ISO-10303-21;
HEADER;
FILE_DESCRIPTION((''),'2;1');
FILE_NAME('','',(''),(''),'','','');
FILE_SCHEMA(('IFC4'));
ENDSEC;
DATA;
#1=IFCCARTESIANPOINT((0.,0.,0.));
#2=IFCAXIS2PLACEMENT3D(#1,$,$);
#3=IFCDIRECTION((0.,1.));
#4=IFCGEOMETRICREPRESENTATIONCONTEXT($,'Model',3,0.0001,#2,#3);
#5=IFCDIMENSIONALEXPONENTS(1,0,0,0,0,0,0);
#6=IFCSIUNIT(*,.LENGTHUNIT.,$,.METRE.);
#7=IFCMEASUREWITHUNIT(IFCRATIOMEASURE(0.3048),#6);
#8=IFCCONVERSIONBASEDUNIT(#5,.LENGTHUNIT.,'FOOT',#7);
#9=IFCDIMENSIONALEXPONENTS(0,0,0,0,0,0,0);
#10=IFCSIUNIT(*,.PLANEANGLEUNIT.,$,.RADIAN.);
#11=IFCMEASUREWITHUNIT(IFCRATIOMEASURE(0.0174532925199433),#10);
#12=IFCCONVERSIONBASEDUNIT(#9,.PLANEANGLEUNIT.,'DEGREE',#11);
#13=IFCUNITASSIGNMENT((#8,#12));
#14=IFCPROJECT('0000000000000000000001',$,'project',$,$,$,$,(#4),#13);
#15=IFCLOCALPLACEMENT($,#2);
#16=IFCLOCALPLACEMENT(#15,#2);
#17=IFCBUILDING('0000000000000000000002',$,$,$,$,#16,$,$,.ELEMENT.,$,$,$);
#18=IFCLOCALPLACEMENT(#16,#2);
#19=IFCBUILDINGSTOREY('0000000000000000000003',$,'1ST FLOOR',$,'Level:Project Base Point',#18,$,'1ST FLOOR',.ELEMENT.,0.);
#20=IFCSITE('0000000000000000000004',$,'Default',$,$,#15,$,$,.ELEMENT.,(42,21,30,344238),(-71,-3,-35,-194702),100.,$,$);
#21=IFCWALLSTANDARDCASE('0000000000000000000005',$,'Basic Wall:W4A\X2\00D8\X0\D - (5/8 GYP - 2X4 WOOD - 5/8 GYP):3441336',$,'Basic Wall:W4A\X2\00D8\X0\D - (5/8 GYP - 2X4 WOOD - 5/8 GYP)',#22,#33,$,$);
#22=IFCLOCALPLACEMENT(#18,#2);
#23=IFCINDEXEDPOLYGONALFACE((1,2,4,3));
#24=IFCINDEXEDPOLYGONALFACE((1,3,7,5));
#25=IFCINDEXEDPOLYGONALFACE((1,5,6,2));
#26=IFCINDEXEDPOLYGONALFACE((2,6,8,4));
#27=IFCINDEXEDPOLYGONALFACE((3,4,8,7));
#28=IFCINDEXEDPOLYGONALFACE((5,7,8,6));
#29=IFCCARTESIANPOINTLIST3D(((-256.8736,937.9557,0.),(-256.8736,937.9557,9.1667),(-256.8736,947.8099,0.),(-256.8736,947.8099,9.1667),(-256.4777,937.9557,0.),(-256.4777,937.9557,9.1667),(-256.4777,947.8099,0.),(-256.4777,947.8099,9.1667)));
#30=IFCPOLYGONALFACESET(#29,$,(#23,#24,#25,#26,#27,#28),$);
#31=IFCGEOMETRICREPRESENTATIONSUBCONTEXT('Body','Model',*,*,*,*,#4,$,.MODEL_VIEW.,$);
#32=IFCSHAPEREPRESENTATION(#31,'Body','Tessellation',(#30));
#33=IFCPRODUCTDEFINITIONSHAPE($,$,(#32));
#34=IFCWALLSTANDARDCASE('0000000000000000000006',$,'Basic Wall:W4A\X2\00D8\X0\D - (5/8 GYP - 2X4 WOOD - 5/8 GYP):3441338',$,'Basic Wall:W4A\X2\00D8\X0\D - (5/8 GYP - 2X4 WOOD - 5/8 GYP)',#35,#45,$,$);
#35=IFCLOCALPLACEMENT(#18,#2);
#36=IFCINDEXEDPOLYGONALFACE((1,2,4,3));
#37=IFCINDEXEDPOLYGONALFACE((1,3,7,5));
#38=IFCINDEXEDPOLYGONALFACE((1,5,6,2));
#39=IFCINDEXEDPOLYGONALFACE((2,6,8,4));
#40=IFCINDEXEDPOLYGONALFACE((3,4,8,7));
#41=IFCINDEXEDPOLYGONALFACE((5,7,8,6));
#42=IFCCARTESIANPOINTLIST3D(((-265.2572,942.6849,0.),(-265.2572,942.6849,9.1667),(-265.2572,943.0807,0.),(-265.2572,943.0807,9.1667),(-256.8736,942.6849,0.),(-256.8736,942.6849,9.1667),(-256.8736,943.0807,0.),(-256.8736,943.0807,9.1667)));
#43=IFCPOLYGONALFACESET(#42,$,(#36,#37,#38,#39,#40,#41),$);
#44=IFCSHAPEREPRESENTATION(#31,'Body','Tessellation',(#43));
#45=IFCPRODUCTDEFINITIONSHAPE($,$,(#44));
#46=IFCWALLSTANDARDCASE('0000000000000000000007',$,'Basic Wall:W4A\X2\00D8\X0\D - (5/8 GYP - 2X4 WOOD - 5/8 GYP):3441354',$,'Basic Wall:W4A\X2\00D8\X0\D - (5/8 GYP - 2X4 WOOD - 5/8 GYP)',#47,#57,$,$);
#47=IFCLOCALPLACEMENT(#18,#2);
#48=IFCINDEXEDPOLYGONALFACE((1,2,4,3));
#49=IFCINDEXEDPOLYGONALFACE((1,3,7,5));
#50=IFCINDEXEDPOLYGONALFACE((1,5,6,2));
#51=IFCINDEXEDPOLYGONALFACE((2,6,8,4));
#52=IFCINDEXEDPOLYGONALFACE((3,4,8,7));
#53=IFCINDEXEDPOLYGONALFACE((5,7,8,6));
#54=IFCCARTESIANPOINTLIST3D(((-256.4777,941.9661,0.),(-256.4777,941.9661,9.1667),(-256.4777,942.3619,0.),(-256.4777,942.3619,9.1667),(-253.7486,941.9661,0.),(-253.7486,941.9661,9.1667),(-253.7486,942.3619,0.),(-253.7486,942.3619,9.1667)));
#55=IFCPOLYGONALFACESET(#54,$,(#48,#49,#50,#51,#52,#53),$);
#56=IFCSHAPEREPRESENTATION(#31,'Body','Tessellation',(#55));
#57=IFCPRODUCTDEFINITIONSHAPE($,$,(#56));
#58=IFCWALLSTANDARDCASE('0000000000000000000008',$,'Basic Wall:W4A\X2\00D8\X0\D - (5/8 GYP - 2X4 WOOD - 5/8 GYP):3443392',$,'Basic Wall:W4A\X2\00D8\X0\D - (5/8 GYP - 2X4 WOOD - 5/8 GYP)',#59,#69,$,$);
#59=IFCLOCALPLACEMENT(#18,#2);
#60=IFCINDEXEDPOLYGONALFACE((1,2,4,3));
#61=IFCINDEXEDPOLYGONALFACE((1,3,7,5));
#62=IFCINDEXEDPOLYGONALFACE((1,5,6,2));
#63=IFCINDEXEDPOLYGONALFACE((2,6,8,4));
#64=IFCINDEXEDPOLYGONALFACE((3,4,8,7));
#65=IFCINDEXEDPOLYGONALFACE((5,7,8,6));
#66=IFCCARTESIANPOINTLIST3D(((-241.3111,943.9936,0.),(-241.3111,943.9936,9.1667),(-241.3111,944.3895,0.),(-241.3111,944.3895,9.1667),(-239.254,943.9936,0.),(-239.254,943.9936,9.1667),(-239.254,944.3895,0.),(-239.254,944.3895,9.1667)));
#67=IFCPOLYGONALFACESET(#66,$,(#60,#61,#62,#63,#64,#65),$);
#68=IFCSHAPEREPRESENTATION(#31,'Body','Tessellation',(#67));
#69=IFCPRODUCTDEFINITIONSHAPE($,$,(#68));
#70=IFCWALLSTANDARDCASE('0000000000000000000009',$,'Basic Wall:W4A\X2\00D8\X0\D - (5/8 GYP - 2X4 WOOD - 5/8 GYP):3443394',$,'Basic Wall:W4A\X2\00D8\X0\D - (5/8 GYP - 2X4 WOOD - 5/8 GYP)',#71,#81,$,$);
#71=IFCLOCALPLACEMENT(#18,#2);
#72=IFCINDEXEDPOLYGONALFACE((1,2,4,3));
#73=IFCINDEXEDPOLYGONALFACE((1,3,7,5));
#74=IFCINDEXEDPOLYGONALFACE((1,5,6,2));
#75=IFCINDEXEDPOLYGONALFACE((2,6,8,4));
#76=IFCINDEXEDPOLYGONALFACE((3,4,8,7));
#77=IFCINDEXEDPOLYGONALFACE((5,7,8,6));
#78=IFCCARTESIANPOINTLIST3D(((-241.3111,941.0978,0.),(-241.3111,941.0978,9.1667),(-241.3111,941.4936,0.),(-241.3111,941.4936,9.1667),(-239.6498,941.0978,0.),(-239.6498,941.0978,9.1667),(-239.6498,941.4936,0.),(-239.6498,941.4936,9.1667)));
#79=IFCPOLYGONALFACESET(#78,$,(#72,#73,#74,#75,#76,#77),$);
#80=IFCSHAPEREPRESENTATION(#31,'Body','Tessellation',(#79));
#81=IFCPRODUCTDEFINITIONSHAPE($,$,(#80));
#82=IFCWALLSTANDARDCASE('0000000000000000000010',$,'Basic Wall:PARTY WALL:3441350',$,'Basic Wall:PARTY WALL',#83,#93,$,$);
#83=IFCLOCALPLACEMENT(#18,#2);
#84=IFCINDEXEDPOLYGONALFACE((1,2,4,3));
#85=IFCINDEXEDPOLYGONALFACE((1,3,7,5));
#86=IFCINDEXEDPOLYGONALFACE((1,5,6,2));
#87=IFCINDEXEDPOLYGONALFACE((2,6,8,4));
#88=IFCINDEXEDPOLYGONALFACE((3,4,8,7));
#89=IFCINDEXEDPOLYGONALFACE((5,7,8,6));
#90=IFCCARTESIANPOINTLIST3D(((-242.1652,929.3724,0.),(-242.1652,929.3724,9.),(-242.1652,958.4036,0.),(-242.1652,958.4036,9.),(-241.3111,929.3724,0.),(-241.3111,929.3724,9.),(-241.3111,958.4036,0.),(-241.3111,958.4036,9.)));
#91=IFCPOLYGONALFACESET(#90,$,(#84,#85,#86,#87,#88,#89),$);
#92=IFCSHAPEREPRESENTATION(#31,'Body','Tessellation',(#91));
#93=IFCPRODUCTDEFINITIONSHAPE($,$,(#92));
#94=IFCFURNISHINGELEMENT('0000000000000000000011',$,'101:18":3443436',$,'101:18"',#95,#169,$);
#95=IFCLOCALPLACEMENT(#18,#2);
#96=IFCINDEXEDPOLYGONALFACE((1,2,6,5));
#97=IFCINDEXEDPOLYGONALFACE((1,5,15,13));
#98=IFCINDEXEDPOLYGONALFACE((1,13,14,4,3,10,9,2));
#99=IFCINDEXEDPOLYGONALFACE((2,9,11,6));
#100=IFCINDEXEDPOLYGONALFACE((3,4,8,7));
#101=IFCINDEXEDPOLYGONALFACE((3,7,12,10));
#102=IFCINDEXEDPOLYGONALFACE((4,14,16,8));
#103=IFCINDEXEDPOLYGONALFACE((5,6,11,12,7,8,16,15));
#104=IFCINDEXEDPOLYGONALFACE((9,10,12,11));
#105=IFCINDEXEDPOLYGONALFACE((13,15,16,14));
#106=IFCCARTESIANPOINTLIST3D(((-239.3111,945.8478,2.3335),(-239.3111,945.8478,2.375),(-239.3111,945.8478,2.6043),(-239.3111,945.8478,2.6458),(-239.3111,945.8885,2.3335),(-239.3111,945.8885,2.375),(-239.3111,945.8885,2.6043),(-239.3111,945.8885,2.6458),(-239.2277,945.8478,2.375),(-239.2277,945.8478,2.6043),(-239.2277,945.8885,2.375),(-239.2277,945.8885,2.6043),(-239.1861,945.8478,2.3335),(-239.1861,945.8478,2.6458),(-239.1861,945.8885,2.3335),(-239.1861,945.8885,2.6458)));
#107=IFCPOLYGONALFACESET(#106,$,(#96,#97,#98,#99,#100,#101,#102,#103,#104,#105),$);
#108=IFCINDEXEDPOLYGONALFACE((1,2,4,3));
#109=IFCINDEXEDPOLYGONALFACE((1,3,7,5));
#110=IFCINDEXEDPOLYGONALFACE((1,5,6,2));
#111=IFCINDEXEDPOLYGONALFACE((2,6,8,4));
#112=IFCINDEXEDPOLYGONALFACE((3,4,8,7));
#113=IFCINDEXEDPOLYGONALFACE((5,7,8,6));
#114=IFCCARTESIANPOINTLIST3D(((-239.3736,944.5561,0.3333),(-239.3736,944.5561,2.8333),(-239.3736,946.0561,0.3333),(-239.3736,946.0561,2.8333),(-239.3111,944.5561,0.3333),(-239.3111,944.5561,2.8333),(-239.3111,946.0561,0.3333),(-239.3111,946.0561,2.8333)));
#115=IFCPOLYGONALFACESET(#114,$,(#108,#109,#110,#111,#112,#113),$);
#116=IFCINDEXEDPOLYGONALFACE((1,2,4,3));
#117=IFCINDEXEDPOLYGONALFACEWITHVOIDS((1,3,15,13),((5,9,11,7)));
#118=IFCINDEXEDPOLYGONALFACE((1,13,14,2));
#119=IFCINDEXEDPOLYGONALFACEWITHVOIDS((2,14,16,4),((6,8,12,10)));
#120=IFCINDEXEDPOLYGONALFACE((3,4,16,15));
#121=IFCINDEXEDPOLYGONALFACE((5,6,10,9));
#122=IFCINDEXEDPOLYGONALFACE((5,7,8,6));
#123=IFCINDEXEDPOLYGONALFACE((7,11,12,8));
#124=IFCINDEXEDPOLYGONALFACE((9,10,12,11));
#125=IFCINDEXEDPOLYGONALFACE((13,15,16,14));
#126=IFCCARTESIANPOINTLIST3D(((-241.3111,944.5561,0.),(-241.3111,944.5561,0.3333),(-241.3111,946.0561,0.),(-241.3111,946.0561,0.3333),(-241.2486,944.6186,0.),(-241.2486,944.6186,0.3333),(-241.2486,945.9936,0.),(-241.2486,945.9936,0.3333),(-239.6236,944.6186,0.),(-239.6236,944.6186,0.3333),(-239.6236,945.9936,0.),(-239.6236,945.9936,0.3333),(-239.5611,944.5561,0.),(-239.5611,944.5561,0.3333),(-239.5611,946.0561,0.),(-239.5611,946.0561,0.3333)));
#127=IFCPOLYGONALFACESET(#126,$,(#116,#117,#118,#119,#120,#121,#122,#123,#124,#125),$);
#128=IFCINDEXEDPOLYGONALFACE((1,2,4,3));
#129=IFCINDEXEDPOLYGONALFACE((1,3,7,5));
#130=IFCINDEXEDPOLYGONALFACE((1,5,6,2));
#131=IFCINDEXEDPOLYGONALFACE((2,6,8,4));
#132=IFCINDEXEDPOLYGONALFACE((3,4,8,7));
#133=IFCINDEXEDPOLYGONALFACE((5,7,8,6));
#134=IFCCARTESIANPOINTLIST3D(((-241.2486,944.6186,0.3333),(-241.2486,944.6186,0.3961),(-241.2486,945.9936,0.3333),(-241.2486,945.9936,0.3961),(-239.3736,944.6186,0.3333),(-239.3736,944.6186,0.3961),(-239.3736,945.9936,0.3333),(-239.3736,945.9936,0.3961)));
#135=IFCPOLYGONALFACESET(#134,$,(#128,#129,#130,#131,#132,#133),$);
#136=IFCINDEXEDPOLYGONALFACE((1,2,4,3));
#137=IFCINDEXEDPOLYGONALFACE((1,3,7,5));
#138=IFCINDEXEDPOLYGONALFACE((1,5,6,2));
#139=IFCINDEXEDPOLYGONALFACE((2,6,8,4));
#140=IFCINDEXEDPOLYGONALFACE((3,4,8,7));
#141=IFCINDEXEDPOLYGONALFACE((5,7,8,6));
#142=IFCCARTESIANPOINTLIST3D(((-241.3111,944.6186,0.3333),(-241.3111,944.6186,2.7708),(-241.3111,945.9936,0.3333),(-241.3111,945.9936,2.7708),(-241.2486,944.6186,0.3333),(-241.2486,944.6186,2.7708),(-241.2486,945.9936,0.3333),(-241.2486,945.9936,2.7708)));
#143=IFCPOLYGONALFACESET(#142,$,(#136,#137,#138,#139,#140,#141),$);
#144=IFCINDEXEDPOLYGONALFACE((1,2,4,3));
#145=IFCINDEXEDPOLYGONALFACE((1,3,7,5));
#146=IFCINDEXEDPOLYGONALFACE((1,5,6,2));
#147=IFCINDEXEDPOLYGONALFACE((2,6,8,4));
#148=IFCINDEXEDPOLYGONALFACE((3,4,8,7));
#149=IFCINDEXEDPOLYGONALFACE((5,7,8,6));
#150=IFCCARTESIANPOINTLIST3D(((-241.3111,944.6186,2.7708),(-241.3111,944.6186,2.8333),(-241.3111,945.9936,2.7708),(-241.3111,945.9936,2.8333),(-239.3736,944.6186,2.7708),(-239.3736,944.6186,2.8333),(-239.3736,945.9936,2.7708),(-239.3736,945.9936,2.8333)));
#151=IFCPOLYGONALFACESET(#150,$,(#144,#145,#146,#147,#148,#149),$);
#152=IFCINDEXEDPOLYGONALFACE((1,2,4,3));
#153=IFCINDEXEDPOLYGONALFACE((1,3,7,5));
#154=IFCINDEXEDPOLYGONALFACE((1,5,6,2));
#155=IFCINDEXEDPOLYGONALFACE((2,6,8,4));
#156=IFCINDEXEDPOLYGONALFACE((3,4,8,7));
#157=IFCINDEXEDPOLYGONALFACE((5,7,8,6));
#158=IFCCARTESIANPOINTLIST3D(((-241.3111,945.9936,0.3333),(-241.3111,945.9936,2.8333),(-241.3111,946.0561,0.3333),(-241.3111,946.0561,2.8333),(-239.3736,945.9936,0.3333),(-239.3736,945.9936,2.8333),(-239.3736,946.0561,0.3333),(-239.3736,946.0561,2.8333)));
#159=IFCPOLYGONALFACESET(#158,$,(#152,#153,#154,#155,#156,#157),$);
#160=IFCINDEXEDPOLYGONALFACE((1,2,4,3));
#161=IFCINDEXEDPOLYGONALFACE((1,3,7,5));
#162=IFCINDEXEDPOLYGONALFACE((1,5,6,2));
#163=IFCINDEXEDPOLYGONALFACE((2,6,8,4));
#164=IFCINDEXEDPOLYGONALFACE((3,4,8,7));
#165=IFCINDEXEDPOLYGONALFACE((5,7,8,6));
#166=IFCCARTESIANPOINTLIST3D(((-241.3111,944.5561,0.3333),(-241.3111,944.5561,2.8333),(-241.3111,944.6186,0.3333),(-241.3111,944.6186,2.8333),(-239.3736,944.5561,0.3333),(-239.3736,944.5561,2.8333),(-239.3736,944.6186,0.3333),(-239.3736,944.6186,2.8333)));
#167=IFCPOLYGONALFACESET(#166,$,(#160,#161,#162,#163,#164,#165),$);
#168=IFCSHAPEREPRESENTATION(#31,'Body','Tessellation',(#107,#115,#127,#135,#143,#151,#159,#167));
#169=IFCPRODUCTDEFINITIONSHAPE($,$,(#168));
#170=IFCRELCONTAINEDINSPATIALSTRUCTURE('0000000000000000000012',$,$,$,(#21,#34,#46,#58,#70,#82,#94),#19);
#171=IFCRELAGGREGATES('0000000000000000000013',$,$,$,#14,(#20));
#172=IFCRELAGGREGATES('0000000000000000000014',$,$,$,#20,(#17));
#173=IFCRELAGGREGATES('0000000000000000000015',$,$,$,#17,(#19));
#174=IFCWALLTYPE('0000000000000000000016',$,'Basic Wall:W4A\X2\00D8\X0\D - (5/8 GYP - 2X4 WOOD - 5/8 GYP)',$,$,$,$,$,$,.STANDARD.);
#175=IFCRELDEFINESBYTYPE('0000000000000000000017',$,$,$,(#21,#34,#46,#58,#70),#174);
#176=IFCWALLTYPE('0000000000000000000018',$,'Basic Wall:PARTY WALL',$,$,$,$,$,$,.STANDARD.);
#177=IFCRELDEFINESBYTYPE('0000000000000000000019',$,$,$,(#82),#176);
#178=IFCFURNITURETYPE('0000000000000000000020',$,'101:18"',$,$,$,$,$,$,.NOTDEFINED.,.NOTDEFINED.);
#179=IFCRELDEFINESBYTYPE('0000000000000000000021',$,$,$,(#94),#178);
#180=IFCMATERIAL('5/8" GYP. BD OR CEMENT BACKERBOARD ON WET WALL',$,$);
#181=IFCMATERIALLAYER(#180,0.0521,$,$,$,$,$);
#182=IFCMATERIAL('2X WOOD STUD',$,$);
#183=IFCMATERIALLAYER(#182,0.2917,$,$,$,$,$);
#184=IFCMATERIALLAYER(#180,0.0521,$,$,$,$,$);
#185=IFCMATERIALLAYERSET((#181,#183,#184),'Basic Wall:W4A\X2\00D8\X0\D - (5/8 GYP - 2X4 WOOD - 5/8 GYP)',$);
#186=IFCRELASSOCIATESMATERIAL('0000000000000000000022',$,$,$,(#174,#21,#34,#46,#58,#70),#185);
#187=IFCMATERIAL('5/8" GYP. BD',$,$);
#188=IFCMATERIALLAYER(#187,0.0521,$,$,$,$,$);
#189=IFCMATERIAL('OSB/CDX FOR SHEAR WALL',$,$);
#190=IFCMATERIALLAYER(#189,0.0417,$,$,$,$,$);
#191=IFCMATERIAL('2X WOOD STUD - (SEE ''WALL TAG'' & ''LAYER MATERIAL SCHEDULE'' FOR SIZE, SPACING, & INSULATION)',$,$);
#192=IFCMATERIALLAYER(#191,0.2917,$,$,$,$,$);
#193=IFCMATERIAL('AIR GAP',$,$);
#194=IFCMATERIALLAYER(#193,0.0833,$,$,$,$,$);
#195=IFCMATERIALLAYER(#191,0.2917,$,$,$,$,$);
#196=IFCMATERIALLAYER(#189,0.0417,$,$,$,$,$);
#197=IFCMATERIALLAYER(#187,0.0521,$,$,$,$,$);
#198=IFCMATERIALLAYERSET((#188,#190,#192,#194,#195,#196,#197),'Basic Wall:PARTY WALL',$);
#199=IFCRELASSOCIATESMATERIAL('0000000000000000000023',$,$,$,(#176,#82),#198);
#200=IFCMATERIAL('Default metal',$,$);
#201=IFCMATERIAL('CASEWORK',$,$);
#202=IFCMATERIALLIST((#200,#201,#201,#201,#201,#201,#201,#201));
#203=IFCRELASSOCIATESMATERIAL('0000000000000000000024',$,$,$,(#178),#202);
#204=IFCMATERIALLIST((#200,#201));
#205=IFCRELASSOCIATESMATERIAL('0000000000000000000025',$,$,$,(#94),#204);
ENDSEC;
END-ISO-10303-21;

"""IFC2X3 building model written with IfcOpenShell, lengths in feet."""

from ifc_helpers import new_model, entity, si_unit, converted_unit, direction, frame, frame_2d, origin, origin_2d_with_axis, place, context, subcontext, project, spatial, polyline, rectangle, outline, extrude, source, transform, mapped, material, material_list, layer, layer_set, layer_usage, type_object, type_shapes, element, save


model = new_model("IFC2X3")

# Units and contexts
model_context = context("Model", 3, precision=0.0001, world=origin(), true_north=direction((0.0, 1.0)))
body_context = subcontext(model_context, "Body", "Model", "MODEL_VIEW")
ifc_project = project(units=[converted_unit("LENGTHUNIT", "FOOT", entity("IfcRatioMeasure", 0.3048), si_unit("LENGTHUNIT", "METRE"), dimensions=[1, 0, 0, 0, 0, 0, 0]), converted_unit("PLANEANGLEUNIT", "DEGREE", entity("IfcRatioMeasure", 0.0174532925199433), si_unit("PLANEANGLEUNIT", "RADIAN"), dimensions=[0, 0, 0, 0, 0, 0, 0])], contexts=[model_context])

# Site, building, storey
site_placement = place(None, origin())
site = spatial("IfcSite", under=ifc_project, at=site_placement, Name="Default", CompositionType="ELEMENT", RefLatitude=(42, 21, 30, 344238), RefLongitude=(-71, -3, -35, -194702), RefElevation=100.0)
building_placement = place(site_placement, origin())
building = spatial("IfcBuilding", under=site, at=building_placement, CompositionType="ELEMENT")
storey_placement = place(building_placement, origin())
storey = spatial("IfcBuildingStorey", under=building, at=storey_placement, Name="1ST FLOOR", ObjectType="Level:Project Base Point", LongName="1ST FLOOR", CompositionType="ELEMENT", Elevation=0.0)

# Shared definitions
ifc_material_1 = material(Name="5/8\" GYP. BD OR CEMENT BACKERBOARD ON WET WALL")
ifc_layer_1 = layer(ifc_material_1, 0.0521)
ifc_material_2 = material(Name="2X WOOD STUD")
ifc_layer_2 = layer(ifc_material_2, 0.2917)
ifc_layer_3 = layer(ifc_material_1, 0.0521)
ifc_layer_set_1 = layer_set([ifc_layer_1, ifc_layer_2, ifc_layer_3], Name="Basic Wall:W4AØD - (5/8 GYP - 2X4 WOOD - 5/8 GYP)")
wall_type_1 = type_object("IfcWallType", Name="Basic Wall:W4AØD - (5/8 GYP - 2X4 WOOD - 5/8 GYP)", PredefinedType="STANDARD", material=ifc_layer_set_1)

# Walls
ifc_layer_usage_1 = layer_usage(ifc_layer_set_1, "AXIS2", "NEGATIVE", 0.1979)
wall_1_placement = place(storey_placement, frame((-256.6757, 937.9557, 0.0), z_axis=(0.0, 0.0, 1.0), x_axis=(0.0, 1.0, 0.0)))
element("IfcWallStandardCase", 1, at=wall_1_placement, inside=storey, type_object=wall_type_1, material=ifc_layer_usage_1, Name="Basic Wall:W4AØD - (5/8 GYP - 2X4 WOOD - 5/8 GYP):3441336", ObjectType="Basic Wall:W4AØD - (5/8 GYP - 2X4 WOOD - 5/8 GYP)", context=body_context, shape_type="SweptSolid", body=[
    extrude(rectangle(XDim=9.8542, YDim=0.3958, at=frame_2d((4.9271, 0.0), x_axis=(-1.0, 0.0))), origin(), (0.0, 0.0, 1.0), 9.1667),
])
ifc_layer_usage_2 = layer_usage(ifc_layer_set_1, "AXIS2", "POSITIVE", -0.1979)
wall_2_placement = place(storey_placement, frame((-256.8736, 942.8828, 0.0), z_axis=(0.0, 0.0, 1.0), x_axis=(-1.0, 0.0, 0.0)))
element("IfcWallStandardCase", 2, at=wall_2_placement, inside=storey, type_object=wall_type_1, material=ifc_layer_usage_2, Name="Basic Wall:W4AØD - (5/8 GYP - 2X4 WOOD - 5/8 GYP):3441338", ObjectType="Basic Wall:W4AØD - (5/8 GYP - 2X4 WOOD - 5/8 GYP)", context=body_context, shape_type="SweptSolid", body=[
    extrude(rectangle(XDim=8.3836, YDim=0.3958, at=frame_2d((4.1918, 0.0), x_axis=(-1.0, 0.0))), origin(), (0.0, 0.0, 1.0), 9.1667),
])
ifc_layer_usage_3 = layer_usage(ifc_layer_set_1, "AXIS2", "NEGATIVE", 0.1979)
wall_3_placement = place(storey_placement, frame((-256.4777, 942.164, 0.0)))
element("IfcWallStandardCase", 3, at=wall_3_placement, inside=storey, type_object=wall_type_1, material=ifc_layer_usage_3, Name="Basic Wall:W4AØD - (5/8 GYP - 2X4 WOOD - 5/8 GYP):3441354", ObjectType="Basic Wall:W4AØD - (5/8 GYP - 2X4 WOOD - 5/8 GYP)", context=body_context, shape_type="SweptSolid", body=[
    extrude(rectangle(XDim=2.7292, YDim=0.3958, at=frame_2d((1.3646, 0.0), x_axis=(-1.0, 0.0))), origin(), (0.0, 0.0, 1.0), 9.1667),
])
ifc_layer_usage_4 = layer_usage(ifc_layer_set_1, "AXIS2", "NEGATIVE", 0.1979)
wall_4_placement = place(storey_placement, frame((-241.3111, 944.1916, 0.0)))
element("IfcWallStandardCase", 4, at=wall_4_placement, inside=storey, type_object=wall_type_1, material=ifc_layer_usage_4, Name="Basic Wall:W4AØD - (5/8 GYP - 2X4 WOOD - 5/8 GYP):3443392", ObjectType="Basic Wall:W4AØD - (5/8 GYP - 2X4 WOOD - 5/8 GYP)", context=body_context, shape_type="SweptSolid", body=[
    extrude(rectangle(XDim=2.0571, YDim=0.3958, at=frame_2d((1.0285, 0.0), x_axis=(-1.0, 0.0))), origin(), (0.0, 0.0, 1.0), 9.1667),
])
ifc_layer_usage_5 = layer_usage(ifc_layer_set_1, "AXIS2", "NEGATIVE", 0.1979)
wall_5_placement = place(storey_placement, frame((-239.6498, 941.2957, 0.0), z_axis=(0.0, 0.0, 1.0), x_axis=(-1.0, 0.0, 0.0)))
element("IfcWallStandardCase", 5, at=wall_5_placement, inside=storey, type_object=wall_type_1, material=ifc_layer_usage_5, Name="Basic Wall:W4AØD - (5/8 GYP - 2X4 WOOD - 5/8 GYP):3443394", ObjectType="Basic Wall:W4AØD - (5/8 GYP - 2X4 WOOD - 5/8 GYP)", context=body_context, shape_type="SweptSolid", body=[
    extrude(rectangle(XDim=1.6612, YDim=0.3958, at=frame_2d((0.8306, 0.0), x_axis=(-1.0, 0.0))), origin(), (0.0, 0.0, 1.0), 9.1667),
])
ifc_material_3 = material(Name="5/8\" GYP. BD")
ifc_layer_4 = layer(ifc_material_3, 0.0521)
ifc_material_4 = material(Name="OSB/CDX FOR SHEAR WALL")
ifc_layer_5 = layer(ifc_material_4, 0.0417)
ifc_material_5 = material(Name="2X WOOD STUD - (SEE 'WALL TAG' & 'LAYER MATERIAL SCHEDULE' FOR SIZE, SPACING, & INSULATION)")
ifc_layer_6 = layer(ifc_material_5, 0.2917)
ifc_material_6 = material(Name="AIR GAP")
ifc_layer_7 = layer(ifc_material_6, 0.0833)
ifc_layer_8 = layer(ifc_material_5, 0.2917)
ifc_layer_9 = layer(ifc_material_4, 0.0417)
ifc_layer_10 = layer(ifc_material_3, 0.0521)
ifc_layer_set_2 = layer_set([ifc_layer_4, ifc_layer_5, ifc_layer_6, ifc_layer_7, ifc_layer_8, ifc_layer_9, ifc_layer_10], Name="Basic Wall:PARTY WALL")
ifc_layer_usage_6 = layer_usage(ifc_layer_set_2, "AXIS2", "POSITIVE", -0.4271)
wall_type_2 = type_object("IfcWallType", Name="Basic Wall:PARTY WALL", PredefinedType="STANDARD", material=ifc_layer_set_2)
wall_6_placement = place(storey_placement, frame((-241.7382, 929.3724, 0.0), z_axis=(0.0, 0.0, 1.0), x_axis=(0.0, 1.0, 0.0)))
element("IfcWallStandardCase", 6, at=wall_6_placement, inside=storey, type_object=wall_type_2, material=ifc_layer_usage_6, Name="Basic Wall:PARTY WALL:3441350", ObjectType="Basic Wall:PARTY WALL", context=body_context, shape_type="SweptSolid", body=[
    extrude(rectangle(XDim=29.0313, YDim=0.8542, at=frame_2d((14.5156, 0.0), x_axis=(-1.0, 0.0))), origin(), (0.0, 0.0, 1.0), 9.0),
])

# Furnishing element
ifc_material_7 = material(Name="Default metal")
ifc_material_8 = material(Name="CASEWORK")
ifc_material_list_1 = material_list([ifc_material_7, ifc_material_8])
ifc_material_list_2 = material_list([ifc_material_7, ifc_material_8, ifc_material_8, ifc_material_8, ifc_material_8, ifc_material_8, ifc_material_8, ifc_material_8])
furniture_type_1 = type_object("IfcFurnitureType", Name="101:18\"", material=ifc_material_list_2)
shared_shape_1 = source(origin(), body_context, "Body", "SweptSolid", [
    extrude(outline(polyline([(0.1146, -0.0521), (0.1562, -0.0521), (0.1562, 0.0729), (-0.1562, 0.0729), (-0.1562, -0.0521), (-0.1146, -0.0521), (-0.1146, 0.0313), (0.1146, 0.0313), (0.1146, -0.0521)])), frame((0.3531, -2.0521, 2.4896), z_axis=(1.0, 0.0, 0.0), x_axis=(0.0, 0.0, 1.0)), (0.0, 0.0, 1.0), 0.0407),
    extrude(rectangle(XDim=0.0625, YDim=1.5, at=frame_2d((0.0, 0.0), x_axis=(1.0, 0.0))), frame((-0.1885, -1.9688, 0.3333), z_axis=(0.0, 0.0, 1.0), x_axis=(0.0, 1.0, 0.0)), (0.0, 0.0, 1.0), 2.5),
    extrude(outline(polyline([(-0.75, -0.875), (0.75, -0.875), (0.75, 0.875), (-0.75, 0.875), (-0.75, -0.875)]), holes=[polyline([(-0.6875, -0.8125), (-0.6875, 0.8125), (0.6875, 0.8125), (0.6875, -0.8125), (-0.6875, -0.8125)])]), frame((-0.1885, -0.875, 0.0)), (0.0, 0.0, 1.0), 0.3333),
    extrude(rectangle(XDim=1.375, YDim=1.875, at=frame_2d((0.0, 0.0), x_axis=(1.0, 0.0))), frame((-0.1885, -1.0, 0.3333), z_axis=(0.0, 0.0, 1.0), x_axis=(-1.0, 0.0, 0.0)), (0.0, 0.0, 1.0), 0.0627),
    extrude(rectangle(XDim=0.0625, YDim=1.375, at=origin_2d_with_axis()), frame((-0.1885, -0.0312, 0.3333), z_axis=(0.0, 0.0, 1.0), x_axis=(0.0, 1.0, 0.0)), (0.0, 0.0, 1.0), 2.4375),
    extrude(rectangle(XDim=1.375, YDim=1.9375, at=origin_2d_with_axis()), frame((-0.1885, -0.9688, 2.7708), z_axis=(0.0, 0.0, 1.0), x_axis=(-1.0, 0.0, 0.0)), (0.0, 0.0, 1.0), 0.0625),
    extrude(rectangle(XDim=0.0625, YDim=1.9375, at=frame_2d((0.0, 0.0), x_axis=(1.0, 0.0))), frame((0.5302, -0.9687, 0.3333)), (0.0, 0.0, 1.0), 2.5),
    extrude(rectangle(XDim=0.0625, YDim=1.9375, at=frame_2d((0.0, 0.0), x_axis=(1.0, 0.0))), frame((-0.9073, -0.9687, 0.3333)), (0.0, 0.0, 1.0), 2.5),
])
type_shapes(furniture_type_1, [shared_shape_1])
furnishing_1_placement = place(storey_placement, frame((-241.3111, 945.4947, 0.0), z_axis=(0.0, 0.0, 1.0), x_axis=(0.0, 1.0, 0.0)))
element("IfcFurnishingElement", 7, at=furnishing_1_placement, inside=storey, type_object=furniture_type_1, material=ifc_material_list_1, Name="101:18\":3443436", ObjectType="101:18\"", context=body_context, shape_type="MappedRepresentation", body=[
    mapped(shared_shape_1, transform((0.0, 0.0, 0.0), scale=1.0)),
])

save(model, "model.ifc")
